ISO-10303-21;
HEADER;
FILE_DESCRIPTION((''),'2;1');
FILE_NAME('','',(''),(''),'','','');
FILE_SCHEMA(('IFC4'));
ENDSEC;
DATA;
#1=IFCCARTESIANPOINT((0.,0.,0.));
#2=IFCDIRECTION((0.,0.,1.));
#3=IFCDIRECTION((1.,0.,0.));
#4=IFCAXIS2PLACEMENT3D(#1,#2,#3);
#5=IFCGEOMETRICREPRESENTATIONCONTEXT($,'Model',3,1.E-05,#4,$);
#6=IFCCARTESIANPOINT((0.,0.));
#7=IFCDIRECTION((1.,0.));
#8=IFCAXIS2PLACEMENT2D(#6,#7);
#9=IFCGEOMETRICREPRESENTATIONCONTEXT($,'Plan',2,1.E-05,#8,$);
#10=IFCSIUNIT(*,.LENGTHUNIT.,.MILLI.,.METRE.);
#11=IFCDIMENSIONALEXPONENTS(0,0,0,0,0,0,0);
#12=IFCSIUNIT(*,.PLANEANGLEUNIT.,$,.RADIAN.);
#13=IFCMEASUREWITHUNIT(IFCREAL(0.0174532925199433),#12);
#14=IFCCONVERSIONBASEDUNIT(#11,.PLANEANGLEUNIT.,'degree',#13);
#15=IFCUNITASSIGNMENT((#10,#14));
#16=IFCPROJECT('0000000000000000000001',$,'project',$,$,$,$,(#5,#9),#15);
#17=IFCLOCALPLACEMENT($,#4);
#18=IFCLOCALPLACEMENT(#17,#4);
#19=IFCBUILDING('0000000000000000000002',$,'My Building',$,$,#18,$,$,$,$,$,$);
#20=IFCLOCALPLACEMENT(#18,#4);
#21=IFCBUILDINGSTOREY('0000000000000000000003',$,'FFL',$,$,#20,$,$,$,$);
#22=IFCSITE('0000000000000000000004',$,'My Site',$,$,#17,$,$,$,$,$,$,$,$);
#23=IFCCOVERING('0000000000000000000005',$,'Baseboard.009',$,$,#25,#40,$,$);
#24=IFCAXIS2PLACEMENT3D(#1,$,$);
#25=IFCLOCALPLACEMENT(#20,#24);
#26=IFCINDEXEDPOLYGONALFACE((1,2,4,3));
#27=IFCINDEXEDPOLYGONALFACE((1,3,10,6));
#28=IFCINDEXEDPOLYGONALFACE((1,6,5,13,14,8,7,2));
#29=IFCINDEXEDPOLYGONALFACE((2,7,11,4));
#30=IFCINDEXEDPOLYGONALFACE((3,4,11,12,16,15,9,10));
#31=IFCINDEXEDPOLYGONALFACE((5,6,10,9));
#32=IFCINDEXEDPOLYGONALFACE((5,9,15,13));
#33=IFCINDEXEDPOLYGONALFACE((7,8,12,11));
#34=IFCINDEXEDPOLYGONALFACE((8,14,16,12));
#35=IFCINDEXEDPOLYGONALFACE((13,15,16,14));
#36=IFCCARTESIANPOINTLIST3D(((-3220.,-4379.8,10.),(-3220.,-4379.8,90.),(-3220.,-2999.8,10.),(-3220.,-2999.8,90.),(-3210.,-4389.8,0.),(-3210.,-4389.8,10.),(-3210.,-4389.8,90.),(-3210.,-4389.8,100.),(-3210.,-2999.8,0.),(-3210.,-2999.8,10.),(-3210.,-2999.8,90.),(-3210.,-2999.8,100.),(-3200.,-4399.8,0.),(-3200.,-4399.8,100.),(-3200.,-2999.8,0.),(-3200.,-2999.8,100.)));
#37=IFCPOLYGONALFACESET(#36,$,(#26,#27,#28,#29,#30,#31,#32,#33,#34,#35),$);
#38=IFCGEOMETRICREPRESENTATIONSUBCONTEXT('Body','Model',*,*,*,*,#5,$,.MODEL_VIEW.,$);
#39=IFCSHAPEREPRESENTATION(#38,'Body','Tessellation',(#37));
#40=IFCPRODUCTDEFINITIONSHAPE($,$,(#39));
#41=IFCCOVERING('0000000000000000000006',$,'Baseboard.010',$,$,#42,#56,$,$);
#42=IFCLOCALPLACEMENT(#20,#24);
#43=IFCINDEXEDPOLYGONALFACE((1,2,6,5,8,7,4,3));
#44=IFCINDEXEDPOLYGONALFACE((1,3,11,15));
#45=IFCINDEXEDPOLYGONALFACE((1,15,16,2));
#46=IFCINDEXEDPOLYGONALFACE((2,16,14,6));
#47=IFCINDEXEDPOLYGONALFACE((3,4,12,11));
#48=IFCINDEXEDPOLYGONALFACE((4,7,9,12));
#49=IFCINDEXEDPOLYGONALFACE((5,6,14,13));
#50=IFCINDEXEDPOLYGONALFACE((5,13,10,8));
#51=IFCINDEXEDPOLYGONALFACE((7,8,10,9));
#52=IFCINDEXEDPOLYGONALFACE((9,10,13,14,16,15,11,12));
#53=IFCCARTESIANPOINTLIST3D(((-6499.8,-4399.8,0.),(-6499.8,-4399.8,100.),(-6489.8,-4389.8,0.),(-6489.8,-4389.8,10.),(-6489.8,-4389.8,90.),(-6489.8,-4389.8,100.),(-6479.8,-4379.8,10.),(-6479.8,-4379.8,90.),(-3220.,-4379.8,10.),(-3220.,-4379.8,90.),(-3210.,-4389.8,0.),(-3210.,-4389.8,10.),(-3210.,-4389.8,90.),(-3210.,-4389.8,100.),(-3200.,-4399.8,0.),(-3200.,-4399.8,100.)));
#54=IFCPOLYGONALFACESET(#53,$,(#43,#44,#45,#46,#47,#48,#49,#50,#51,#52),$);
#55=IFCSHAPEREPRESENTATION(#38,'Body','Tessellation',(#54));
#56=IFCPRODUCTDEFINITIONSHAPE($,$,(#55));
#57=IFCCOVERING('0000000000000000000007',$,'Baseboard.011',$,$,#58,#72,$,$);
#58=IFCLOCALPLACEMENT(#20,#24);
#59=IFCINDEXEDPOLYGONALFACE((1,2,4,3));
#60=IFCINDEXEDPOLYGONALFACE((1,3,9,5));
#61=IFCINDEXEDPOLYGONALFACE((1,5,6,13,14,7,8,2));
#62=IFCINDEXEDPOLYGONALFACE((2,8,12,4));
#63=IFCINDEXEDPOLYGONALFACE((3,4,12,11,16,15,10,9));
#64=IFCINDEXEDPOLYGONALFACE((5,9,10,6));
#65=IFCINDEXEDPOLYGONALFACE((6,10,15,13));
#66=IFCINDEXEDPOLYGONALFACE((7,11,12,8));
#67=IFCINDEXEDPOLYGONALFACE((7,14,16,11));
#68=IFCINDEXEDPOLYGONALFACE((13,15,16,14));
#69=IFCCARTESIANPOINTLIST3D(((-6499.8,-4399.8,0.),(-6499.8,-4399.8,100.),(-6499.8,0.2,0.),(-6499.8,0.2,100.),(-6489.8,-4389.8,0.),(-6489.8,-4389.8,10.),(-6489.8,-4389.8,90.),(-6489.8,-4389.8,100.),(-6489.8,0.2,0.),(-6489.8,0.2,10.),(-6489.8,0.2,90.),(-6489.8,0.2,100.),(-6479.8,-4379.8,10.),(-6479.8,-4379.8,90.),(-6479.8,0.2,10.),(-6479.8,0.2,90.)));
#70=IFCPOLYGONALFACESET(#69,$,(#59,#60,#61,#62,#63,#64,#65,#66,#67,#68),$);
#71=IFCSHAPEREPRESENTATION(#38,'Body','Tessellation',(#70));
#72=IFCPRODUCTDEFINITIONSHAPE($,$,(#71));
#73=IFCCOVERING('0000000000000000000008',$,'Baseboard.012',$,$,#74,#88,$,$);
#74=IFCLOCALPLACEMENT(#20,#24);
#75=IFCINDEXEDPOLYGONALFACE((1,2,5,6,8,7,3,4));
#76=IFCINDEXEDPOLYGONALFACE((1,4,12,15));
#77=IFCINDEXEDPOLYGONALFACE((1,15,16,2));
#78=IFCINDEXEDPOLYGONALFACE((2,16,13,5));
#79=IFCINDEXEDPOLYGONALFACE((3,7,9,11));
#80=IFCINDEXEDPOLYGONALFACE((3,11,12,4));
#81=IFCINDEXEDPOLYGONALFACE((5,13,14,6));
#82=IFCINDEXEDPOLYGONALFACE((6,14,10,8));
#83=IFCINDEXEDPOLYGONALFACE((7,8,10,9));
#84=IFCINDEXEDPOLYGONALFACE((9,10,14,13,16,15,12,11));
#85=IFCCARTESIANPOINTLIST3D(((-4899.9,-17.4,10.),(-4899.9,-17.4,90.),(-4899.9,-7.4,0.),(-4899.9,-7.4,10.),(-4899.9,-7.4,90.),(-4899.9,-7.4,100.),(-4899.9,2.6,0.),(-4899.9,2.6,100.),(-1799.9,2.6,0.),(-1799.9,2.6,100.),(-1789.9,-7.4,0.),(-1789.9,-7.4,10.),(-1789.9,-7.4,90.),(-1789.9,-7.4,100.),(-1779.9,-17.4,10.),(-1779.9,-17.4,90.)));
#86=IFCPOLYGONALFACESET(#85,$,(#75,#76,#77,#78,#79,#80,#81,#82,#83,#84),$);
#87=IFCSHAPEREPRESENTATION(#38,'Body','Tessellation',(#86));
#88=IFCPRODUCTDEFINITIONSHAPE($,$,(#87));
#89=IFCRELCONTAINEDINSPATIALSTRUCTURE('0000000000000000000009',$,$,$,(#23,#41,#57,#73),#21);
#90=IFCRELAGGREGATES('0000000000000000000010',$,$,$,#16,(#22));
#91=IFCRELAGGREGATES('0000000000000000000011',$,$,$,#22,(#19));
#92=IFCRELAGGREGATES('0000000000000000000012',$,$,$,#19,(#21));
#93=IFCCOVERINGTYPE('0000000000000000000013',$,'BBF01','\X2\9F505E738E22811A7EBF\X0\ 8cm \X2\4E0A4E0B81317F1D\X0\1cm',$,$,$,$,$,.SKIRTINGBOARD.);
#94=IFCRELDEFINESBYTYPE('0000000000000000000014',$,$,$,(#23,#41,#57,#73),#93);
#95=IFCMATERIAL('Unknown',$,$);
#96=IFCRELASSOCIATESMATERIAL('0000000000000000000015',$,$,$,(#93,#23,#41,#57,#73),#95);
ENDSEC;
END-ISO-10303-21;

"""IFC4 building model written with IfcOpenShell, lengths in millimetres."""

from ifc_helpers import new_model, entity, si_unit, converted_unit, frame, origin_with_axes, origin_2d_with_axis, place, context, subcontext, project, spatial, indexed_curve, outline, extrude, clip, halfspace, material, material_profile, profile_set, profile_usage, type_object, element, save


model = new_model("IFC4")

# Units and contexts
model_context = context("Model", 3, precision=1e-05, world=origin_with_axes())
plan_context = context("Plan", 2, precision=1e-05, world=origin_2d_with_axis())
body_context_1 = subcontext(model_context, "Body", "Model", "MODEL_VIEW")
ifc_project = project(units=[si_unit("LENGTHUNIT", "METRE", prefix="MILLI"), converted_unit("PLANEANGLEUNIT", "degree", entity("IfcReal", 0.0174532925199433), si_unit("PLANEANGLEUNIT", "RADIAN"), dimensions=[0, 0, 0, 0, 0, 0, 0])], contexts=[model_context, plan_context])

# Site, building, storey
site_placement = place(None, origin_with_axes())
site = spatial("IfcSite", under=ifc_project, at=site_placement, Name="My Site")
building_placement = place(site_placement, origin_with_axes())
building = spatial("IfcBuilding", under=site, at=building_placement, Name="My Building")
storey_placement = place(building_placement, origin_with_axes())
storey = spatial("IfcBuildingStorey", under=building, at=storey_placement, Name="FFL")

# Coverings
ifc_material_1 = material(Name="Unknown")
ifc_material_profile = material_profile(ifc_material_1, outline(indexed_curve([(0.0, 100.0), (10.0, 100.0), (10.0, 90.0), (20.0, 90.0), (20.0, 10.0), (10.0, 10.0), (10.0, 0.0), (0.0, 0.0), (0.0, 100.0)])))
ifc_profile_set = profile_set([ifc_material_profile])
covering_type_1 = type_object("IfcCoveringType", Name="BBF01", Description="齐平踢脚线 8cm 上下脱缝1cm", PredefinedType="SKIRTINGBOARD", material=ifc_profile_set)
ifc_profile_usage_1 = profile_usage(ifc_profile_set, cardinal=5)
covering_1_placement = place(storey_placement, frame((-3200.0, -4399.8, 0.0), z_axis=(0.000001, 1.0, 0.0), x_axis=(-1.0, 0.000001, 0.0)))
element("IfcCovering", 1, at=covering_1_placement, inside=storey, type_object=covering_type_1, material=ifc_profile_usage_1, Name="Baseboard.009", context=body_context_1, shape_type="Clipping", body=[
    clip(extrude(outline(indexed_curve([(0.0, 100.0), (10.0, 100.0), (10.0, 90.0), (20.0, 90.0), (20.0, 10.0), (10.0, 10.0), (10.0, 0.0), (0.0, 0.0), (0.0, 100.0)])), origin_with_axes(), (0.0, 0.0, 1.0), 1400.0), halfspace(frame((0.0, 0.0, 0.0), z_axis=(0.707106, 0.0, -0.707107), x_axis=(0.0, -1.0, 0.0)), False)),
])
ifc_profile_usage_2 = profile_usage(ifc_profile_set, cardinal=5)
covering_2_placement = place(storey_placement, frame((-6499.8, -4399.8, 0.0), z_axis=(1.0, -0.000001, 0.0), x_axis=(0.000001, 1.0, 0.0)))
element("IfcCovering", 2, at=covering_2_placement, inside=storey, type_object=covering_type_1, material=ifc_profile_usage_2, Name="Baseboard.010", context=body_context_1, shape_type="Clipping", body=[
    clip(clip(extrude(outline(indexed_curve([(0.0, 100.0), (10.0, 100.0), (10.0, 90.0), (20.0, 90.0), (20.0, 10.0), (10.0, 10.0), (10.0, 0.0), (0.0, 0.0), (0.0, 100.0)])), origin_with_axes(), (0.0, 0.0, 1.0), 3299.8), halfspace(frame((0.0, 0.0, 0.0), z_axis=(0.707106, 0.0, -0.707107), x_axis=(0.0, -1.0, 0.0)), False)), halfspace(frame((0.0, 0.0, 3299.8), z_axis=(0.707107, 0.0, 0.707106), x_axis=(0.0, -1.0, 0.0)), False)),
])
ifc_profile_usage_3 = profile_usage(ifc_profile_set, cardinal=5)
covering_3_placement = place(storey_placement, frame((-6499.8, 0.2, 0.0), z_axis=(-0.000001, -1.0, 0.0), x_axis=(1.0, -0.000001, 0.0)))
element("IfcCovering", 3, at=covering_3_placement, inside=storey, type_object=covering_type_1, material=ifc_profile_usage_3, Name="Baseboard.011", context=body_context_1, shape_type="Clipping", body=[
    clip(extrude(outline(indexed_curve([(0.0, 100.0), (10.0, 100.0), (10.0, 90.0), (20.0, 90.0), (20.0, 10.0), (10.0, 10.0), (10.0, 0.0), (0.0, 0.0), (0.0, 100.0)])), origin_with_axes(), (0.0, 0.0, 1.0), 4400.0), halfspace(frame((0.0, 0.0, 4400.0), z_axis=(0.707107, 0.0, 0.707106), x_axis=(0.0, -1.0, 0.0)), False)),
])
ifc_profile_usage_4 = profile_usage(ifc_profile_set, cardinal=5)
covering_4_placement = place(storey_placement, frame((-1779.9, 2.6, 0.0), z_axis=(-1.0, 0.000001, 0.0), x_axis=(-0.000001, -1.0, 0.0)))
element("IfcCovering", 4, at=covering_4_placement, inside=storey, type_object=covering_type_1, material=ifc_profile_usage_4, Name="Baseboard.012", context=body_context_1, shape_type="Clipping", body=[
    clip(extrude(outline(indexed_curve([(0.0, 100.0), (10.0, 100.0), (10.0, 90.0), (20.0, 90.0), (20.0, 10.0), (10.0, 10.0), (10.0, 0.0), (0.0, 0.0), (0.0, 100.0)])), origin_with_axes(), (0.0, 0.0, 1.0), 3120.0), halfspace(frame((20.0, 0.0, 0.0), z_axis=(-0.707107, 0.0, -0.707107), x_axis=(0.0, 1.0, 0.0)), False)),
])

save(model, "model.ifc")
